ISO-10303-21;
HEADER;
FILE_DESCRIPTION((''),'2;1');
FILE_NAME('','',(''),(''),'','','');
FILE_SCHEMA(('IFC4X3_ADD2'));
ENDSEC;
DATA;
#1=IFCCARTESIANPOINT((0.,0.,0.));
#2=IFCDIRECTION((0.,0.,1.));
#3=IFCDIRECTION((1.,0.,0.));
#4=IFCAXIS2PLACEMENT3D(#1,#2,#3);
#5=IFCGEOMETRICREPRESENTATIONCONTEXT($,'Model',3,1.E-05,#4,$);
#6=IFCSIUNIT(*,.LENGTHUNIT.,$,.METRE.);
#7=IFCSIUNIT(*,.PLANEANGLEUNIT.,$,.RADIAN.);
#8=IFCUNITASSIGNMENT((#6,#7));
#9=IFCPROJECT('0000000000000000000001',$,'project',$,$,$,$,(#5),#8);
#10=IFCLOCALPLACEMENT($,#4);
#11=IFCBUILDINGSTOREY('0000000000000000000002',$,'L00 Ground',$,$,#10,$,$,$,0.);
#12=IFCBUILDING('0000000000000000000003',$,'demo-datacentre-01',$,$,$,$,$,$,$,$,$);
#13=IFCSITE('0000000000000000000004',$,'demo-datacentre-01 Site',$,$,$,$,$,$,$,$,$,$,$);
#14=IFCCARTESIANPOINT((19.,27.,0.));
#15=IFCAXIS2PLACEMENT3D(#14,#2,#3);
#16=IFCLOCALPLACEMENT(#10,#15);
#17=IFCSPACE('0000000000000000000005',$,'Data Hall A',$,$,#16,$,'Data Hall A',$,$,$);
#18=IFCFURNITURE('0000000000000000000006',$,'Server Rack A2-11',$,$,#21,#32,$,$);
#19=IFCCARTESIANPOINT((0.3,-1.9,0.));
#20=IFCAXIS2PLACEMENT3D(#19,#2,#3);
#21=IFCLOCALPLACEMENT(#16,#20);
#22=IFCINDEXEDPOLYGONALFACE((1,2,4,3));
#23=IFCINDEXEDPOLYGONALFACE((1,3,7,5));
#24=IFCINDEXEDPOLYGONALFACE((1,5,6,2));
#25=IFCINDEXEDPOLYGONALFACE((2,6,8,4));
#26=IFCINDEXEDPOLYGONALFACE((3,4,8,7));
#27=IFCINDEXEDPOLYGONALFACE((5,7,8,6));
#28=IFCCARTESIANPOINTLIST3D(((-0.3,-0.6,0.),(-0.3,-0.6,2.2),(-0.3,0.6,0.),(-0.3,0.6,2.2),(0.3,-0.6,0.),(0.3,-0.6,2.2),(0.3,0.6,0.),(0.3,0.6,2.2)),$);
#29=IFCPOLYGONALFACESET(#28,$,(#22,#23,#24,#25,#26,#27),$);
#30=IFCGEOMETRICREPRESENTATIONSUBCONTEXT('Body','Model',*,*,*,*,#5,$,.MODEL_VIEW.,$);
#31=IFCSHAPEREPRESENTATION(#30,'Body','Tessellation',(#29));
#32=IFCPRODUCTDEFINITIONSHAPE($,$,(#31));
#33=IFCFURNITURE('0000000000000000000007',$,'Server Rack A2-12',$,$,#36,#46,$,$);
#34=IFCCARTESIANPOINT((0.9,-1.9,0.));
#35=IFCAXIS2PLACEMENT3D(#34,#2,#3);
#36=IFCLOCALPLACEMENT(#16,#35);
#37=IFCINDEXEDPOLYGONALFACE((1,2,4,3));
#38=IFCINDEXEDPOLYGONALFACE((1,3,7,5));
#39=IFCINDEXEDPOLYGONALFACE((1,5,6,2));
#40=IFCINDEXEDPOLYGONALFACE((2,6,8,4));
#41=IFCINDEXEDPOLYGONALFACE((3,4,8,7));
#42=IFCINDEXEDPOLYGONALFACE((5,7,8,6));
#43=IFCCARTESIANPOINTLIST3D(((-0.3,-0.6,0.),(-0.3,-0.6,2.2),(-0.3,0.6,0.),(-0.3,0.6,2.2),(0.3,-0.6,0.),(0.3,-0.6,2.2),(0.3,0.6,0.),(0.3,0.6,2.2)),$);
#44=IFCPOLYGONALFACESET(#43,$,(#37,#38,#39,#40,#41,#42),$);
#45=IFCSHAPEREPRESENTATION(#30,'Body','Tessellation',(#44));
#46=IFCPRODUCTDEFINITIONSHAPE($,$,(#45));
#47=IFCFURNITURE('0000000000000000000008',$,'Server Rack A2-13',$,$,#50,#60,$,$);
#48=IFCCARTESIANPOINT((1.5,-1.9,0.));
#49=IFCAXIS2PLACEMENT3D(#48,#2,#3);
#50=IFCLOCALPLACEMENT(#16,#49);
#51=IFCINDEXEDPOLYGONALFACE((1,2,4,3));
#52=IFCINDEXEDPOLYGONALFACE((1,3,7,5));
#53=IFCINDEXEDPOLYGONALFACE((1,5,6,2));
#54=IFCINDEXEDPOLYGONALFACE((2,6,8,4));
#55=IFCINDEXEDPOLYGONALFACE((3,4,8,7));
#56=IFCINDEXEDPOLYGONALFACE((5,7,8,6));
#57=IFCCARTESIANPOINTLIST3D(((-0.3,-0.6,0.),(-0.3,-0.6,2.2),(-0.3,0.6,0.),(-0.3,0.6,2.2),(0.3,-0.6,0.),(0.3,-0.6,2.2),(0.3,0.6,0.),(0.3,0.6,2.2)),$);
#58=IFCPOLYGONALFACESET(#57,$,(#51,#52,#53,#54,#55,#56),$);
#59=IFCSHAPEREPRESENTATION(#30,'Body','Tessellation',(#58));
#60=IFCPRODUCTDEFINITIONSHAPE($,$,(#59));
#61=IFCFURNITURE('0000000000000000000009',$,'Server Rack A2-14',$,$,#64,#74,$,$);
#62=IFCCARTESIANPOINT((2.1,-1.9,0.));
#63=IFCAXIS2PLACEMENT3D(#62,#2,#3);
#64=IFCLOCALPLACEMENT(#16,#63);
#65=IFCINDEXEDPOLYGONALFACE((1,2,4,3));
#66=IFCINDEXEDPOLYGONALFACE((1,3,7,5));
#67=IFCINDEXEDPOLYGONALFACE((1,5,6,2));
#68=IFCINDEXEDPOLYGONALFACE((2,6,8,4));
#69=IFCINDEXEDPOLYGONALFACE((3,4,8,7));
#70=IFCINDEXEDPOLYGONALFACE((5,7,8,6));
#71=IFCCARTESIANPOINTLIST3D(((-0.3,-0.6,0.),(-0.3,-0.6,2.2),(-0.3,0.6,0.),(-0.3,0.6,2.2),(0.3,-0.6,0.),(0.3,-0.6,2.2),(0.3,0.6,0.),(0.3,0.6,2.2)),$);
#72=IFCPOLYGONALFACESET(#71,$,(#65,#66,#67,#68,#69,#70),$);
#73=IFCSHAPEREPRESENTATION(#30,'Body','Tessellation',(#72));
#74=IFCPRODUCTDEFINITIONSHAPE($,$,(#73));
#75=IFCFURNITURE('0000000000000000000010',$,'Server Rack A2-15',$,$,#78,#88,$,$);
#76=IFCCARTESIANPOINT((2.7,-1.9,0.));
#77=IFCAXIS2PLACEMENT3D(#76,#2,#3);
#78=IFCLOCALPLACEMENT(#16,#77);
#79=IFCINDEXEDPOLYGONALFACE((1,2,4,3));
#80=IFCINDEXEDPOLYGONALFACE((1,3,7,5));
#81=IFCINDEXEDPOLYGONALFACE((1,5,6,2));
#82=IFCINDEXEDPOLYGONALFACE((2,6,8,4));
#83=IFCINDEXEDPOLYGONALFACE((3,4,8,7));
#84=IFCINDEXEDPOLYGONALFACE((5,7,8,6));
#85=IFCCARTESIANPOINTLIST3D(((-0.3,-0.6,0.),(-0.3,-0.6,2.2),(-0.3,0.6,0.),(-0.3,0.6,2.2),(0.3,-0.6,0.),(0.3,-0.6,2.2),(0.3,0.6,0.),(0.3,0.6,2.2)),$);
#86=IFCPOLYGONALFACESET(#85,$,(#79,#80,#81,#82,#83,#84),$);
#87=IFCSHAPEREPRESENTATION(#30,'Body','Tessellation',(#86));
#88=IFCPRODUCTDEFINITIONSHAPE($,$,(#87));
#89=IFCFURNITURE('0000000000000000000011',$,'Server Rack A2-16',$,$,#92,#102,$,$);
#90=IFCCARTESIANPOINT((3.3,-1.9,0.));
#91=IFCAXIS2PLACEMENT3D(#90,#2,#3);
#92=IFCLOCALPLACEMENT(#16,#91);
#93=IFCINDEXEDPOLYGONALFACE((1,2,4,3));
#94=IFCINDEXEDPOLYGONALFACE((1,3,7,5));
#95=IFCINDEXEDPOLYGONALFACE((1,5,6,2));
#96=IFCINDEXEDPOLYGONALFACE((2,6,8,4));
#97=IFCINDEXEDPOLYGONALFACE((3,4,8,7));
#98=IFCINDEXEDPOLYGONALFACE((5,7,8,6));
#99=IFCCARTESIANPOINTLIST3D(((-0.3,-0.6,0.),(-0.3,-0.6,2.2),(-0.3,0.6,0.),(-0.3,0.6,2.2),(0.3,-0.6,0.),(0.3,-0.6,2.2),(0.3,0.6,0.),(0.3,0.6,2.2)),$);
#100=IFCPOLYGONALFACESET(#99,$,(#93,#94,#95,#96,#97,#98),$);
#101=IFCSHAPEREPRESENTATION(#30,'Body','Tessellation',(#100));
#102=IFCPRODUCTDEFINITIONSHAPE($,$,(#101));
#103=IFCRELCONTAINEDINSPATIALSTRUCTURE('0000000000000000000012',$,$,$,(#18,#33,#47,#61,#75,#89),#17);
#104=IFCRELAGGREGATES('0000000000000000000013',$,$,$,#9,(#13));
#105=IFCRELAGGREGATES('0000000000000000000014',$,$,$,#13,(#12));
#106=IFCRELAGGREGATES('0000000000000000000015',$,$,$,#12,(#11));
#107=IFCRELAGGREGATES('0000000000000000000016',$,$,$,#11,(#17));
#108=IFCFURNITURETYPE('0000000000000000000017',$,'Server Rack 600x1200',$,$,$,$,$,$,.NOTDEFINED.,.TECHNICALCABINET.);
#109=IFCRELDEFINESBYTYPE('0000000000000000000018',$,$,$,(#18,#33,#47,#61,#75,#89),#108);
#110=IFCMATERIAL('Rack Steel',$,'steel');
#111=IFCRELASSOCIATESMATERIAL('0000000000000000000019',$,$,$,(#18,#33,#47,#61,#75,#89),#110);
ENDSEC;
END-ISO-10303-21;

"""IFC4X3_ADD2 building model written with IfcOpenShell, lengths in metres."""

from ifc_helpers import new_model, si_unit, frame, origin_with_axes, place, context, subcontext, project, spatial, rectangle, extrude, material, type_object, element, save


model = new_model("IFC4X3_ADD2")

# Units and contexts
model_context = context("Model", 3, precision=1e-05, world=origin_with_axes())
body_context = subcontext(model_context, "Body", "Model", "MODEL_VIEW")
ifc_project = project(units=[si_unit("LENGTHUNIT", "METRE"), si_unit("PLANEANGLEUNIT", "RADIAN")], contexts=[model_context])

# Site, building, storey
site = spatial("IfcSite", under=ifc_project, Name="demo-datacentre-01 Site")
building = spatial("IfcBuilding", under=site, Name="demo-datacentre-01")
storey_placement = place(None, origin_with_axes())
storey = spatial("IfcBuildingStorey", under=building, at=storey_placement, Name="L00 Ground", Elevation=0.0)

# Shared definitions
space_placement = place(storey_placement, frame((19.0, 27.0, 0.0), z_axis=(0.0, 0.0, 1.0), x_axis=(1.0, 0.0, 0.0)))
space = spatial("IfcSpace", under=storey, at=space_placement, Name="Data Hall A", LongName="Data Hall A")

# Furniture
ifc_material_1 = material(Name="Rack Steel", Category="steel")
furniture_type = type_object("IfcFurnitureType", Name="Server Rack 600x1200", AssemblyPlace="NOTDEFINED", PredefinedType="TECHNICALCABINET")
for number, where, z_axis, x_axis, name in (
    (1, (0.3, -1.9, 0.0), (0.0, 0.0, 1.0), (1.0, 0.0, 0.0), "Server Rack A2-11"),
    (2, (0.9, -1.9, 0.0), (0.0, 0.0, 1.0), (1.0, 0.0, 0.0), "Server Rack A2-12"),
    (3, (1.5, -1.9, 0.0), (0.0, 0.0, 1.0), (1.0, 0.0, 0.0), "Server Rack A2-13"),
    (4, (2.1, -1.9, 0.0), (0.0, 0.0, 1.0), (1.0, 0.0, 0.0), "Server Rack A2-14"),
    (5, (2.7, -1.9, 0.0), (0.0, 0.0, 1.0), (1.0, 0.0, 0.0), "Server Rack A2-15"),
    (6, (3.3, -1.9, 0.0), (0.0, 0.0, 1.0), (1.0, 0.0, 0.0), "Server Rack A2-16"),
):
    element("IfcFurniture", number, at=place(space_placement, frame(where, z_axis=z_axis, x_axis=x_axis)), inside=space, type_object=furniture_type, material=ifc_material_1, Name=name, context=body_context, shape_type="SweptSolid", body=[
        extrude(rectangle(XDim=0.6, YDim=1.2), origin_with_axes(), (0.0, 0.0, 1.0), 2.2),
    ])

save(model, "model.ifc")
